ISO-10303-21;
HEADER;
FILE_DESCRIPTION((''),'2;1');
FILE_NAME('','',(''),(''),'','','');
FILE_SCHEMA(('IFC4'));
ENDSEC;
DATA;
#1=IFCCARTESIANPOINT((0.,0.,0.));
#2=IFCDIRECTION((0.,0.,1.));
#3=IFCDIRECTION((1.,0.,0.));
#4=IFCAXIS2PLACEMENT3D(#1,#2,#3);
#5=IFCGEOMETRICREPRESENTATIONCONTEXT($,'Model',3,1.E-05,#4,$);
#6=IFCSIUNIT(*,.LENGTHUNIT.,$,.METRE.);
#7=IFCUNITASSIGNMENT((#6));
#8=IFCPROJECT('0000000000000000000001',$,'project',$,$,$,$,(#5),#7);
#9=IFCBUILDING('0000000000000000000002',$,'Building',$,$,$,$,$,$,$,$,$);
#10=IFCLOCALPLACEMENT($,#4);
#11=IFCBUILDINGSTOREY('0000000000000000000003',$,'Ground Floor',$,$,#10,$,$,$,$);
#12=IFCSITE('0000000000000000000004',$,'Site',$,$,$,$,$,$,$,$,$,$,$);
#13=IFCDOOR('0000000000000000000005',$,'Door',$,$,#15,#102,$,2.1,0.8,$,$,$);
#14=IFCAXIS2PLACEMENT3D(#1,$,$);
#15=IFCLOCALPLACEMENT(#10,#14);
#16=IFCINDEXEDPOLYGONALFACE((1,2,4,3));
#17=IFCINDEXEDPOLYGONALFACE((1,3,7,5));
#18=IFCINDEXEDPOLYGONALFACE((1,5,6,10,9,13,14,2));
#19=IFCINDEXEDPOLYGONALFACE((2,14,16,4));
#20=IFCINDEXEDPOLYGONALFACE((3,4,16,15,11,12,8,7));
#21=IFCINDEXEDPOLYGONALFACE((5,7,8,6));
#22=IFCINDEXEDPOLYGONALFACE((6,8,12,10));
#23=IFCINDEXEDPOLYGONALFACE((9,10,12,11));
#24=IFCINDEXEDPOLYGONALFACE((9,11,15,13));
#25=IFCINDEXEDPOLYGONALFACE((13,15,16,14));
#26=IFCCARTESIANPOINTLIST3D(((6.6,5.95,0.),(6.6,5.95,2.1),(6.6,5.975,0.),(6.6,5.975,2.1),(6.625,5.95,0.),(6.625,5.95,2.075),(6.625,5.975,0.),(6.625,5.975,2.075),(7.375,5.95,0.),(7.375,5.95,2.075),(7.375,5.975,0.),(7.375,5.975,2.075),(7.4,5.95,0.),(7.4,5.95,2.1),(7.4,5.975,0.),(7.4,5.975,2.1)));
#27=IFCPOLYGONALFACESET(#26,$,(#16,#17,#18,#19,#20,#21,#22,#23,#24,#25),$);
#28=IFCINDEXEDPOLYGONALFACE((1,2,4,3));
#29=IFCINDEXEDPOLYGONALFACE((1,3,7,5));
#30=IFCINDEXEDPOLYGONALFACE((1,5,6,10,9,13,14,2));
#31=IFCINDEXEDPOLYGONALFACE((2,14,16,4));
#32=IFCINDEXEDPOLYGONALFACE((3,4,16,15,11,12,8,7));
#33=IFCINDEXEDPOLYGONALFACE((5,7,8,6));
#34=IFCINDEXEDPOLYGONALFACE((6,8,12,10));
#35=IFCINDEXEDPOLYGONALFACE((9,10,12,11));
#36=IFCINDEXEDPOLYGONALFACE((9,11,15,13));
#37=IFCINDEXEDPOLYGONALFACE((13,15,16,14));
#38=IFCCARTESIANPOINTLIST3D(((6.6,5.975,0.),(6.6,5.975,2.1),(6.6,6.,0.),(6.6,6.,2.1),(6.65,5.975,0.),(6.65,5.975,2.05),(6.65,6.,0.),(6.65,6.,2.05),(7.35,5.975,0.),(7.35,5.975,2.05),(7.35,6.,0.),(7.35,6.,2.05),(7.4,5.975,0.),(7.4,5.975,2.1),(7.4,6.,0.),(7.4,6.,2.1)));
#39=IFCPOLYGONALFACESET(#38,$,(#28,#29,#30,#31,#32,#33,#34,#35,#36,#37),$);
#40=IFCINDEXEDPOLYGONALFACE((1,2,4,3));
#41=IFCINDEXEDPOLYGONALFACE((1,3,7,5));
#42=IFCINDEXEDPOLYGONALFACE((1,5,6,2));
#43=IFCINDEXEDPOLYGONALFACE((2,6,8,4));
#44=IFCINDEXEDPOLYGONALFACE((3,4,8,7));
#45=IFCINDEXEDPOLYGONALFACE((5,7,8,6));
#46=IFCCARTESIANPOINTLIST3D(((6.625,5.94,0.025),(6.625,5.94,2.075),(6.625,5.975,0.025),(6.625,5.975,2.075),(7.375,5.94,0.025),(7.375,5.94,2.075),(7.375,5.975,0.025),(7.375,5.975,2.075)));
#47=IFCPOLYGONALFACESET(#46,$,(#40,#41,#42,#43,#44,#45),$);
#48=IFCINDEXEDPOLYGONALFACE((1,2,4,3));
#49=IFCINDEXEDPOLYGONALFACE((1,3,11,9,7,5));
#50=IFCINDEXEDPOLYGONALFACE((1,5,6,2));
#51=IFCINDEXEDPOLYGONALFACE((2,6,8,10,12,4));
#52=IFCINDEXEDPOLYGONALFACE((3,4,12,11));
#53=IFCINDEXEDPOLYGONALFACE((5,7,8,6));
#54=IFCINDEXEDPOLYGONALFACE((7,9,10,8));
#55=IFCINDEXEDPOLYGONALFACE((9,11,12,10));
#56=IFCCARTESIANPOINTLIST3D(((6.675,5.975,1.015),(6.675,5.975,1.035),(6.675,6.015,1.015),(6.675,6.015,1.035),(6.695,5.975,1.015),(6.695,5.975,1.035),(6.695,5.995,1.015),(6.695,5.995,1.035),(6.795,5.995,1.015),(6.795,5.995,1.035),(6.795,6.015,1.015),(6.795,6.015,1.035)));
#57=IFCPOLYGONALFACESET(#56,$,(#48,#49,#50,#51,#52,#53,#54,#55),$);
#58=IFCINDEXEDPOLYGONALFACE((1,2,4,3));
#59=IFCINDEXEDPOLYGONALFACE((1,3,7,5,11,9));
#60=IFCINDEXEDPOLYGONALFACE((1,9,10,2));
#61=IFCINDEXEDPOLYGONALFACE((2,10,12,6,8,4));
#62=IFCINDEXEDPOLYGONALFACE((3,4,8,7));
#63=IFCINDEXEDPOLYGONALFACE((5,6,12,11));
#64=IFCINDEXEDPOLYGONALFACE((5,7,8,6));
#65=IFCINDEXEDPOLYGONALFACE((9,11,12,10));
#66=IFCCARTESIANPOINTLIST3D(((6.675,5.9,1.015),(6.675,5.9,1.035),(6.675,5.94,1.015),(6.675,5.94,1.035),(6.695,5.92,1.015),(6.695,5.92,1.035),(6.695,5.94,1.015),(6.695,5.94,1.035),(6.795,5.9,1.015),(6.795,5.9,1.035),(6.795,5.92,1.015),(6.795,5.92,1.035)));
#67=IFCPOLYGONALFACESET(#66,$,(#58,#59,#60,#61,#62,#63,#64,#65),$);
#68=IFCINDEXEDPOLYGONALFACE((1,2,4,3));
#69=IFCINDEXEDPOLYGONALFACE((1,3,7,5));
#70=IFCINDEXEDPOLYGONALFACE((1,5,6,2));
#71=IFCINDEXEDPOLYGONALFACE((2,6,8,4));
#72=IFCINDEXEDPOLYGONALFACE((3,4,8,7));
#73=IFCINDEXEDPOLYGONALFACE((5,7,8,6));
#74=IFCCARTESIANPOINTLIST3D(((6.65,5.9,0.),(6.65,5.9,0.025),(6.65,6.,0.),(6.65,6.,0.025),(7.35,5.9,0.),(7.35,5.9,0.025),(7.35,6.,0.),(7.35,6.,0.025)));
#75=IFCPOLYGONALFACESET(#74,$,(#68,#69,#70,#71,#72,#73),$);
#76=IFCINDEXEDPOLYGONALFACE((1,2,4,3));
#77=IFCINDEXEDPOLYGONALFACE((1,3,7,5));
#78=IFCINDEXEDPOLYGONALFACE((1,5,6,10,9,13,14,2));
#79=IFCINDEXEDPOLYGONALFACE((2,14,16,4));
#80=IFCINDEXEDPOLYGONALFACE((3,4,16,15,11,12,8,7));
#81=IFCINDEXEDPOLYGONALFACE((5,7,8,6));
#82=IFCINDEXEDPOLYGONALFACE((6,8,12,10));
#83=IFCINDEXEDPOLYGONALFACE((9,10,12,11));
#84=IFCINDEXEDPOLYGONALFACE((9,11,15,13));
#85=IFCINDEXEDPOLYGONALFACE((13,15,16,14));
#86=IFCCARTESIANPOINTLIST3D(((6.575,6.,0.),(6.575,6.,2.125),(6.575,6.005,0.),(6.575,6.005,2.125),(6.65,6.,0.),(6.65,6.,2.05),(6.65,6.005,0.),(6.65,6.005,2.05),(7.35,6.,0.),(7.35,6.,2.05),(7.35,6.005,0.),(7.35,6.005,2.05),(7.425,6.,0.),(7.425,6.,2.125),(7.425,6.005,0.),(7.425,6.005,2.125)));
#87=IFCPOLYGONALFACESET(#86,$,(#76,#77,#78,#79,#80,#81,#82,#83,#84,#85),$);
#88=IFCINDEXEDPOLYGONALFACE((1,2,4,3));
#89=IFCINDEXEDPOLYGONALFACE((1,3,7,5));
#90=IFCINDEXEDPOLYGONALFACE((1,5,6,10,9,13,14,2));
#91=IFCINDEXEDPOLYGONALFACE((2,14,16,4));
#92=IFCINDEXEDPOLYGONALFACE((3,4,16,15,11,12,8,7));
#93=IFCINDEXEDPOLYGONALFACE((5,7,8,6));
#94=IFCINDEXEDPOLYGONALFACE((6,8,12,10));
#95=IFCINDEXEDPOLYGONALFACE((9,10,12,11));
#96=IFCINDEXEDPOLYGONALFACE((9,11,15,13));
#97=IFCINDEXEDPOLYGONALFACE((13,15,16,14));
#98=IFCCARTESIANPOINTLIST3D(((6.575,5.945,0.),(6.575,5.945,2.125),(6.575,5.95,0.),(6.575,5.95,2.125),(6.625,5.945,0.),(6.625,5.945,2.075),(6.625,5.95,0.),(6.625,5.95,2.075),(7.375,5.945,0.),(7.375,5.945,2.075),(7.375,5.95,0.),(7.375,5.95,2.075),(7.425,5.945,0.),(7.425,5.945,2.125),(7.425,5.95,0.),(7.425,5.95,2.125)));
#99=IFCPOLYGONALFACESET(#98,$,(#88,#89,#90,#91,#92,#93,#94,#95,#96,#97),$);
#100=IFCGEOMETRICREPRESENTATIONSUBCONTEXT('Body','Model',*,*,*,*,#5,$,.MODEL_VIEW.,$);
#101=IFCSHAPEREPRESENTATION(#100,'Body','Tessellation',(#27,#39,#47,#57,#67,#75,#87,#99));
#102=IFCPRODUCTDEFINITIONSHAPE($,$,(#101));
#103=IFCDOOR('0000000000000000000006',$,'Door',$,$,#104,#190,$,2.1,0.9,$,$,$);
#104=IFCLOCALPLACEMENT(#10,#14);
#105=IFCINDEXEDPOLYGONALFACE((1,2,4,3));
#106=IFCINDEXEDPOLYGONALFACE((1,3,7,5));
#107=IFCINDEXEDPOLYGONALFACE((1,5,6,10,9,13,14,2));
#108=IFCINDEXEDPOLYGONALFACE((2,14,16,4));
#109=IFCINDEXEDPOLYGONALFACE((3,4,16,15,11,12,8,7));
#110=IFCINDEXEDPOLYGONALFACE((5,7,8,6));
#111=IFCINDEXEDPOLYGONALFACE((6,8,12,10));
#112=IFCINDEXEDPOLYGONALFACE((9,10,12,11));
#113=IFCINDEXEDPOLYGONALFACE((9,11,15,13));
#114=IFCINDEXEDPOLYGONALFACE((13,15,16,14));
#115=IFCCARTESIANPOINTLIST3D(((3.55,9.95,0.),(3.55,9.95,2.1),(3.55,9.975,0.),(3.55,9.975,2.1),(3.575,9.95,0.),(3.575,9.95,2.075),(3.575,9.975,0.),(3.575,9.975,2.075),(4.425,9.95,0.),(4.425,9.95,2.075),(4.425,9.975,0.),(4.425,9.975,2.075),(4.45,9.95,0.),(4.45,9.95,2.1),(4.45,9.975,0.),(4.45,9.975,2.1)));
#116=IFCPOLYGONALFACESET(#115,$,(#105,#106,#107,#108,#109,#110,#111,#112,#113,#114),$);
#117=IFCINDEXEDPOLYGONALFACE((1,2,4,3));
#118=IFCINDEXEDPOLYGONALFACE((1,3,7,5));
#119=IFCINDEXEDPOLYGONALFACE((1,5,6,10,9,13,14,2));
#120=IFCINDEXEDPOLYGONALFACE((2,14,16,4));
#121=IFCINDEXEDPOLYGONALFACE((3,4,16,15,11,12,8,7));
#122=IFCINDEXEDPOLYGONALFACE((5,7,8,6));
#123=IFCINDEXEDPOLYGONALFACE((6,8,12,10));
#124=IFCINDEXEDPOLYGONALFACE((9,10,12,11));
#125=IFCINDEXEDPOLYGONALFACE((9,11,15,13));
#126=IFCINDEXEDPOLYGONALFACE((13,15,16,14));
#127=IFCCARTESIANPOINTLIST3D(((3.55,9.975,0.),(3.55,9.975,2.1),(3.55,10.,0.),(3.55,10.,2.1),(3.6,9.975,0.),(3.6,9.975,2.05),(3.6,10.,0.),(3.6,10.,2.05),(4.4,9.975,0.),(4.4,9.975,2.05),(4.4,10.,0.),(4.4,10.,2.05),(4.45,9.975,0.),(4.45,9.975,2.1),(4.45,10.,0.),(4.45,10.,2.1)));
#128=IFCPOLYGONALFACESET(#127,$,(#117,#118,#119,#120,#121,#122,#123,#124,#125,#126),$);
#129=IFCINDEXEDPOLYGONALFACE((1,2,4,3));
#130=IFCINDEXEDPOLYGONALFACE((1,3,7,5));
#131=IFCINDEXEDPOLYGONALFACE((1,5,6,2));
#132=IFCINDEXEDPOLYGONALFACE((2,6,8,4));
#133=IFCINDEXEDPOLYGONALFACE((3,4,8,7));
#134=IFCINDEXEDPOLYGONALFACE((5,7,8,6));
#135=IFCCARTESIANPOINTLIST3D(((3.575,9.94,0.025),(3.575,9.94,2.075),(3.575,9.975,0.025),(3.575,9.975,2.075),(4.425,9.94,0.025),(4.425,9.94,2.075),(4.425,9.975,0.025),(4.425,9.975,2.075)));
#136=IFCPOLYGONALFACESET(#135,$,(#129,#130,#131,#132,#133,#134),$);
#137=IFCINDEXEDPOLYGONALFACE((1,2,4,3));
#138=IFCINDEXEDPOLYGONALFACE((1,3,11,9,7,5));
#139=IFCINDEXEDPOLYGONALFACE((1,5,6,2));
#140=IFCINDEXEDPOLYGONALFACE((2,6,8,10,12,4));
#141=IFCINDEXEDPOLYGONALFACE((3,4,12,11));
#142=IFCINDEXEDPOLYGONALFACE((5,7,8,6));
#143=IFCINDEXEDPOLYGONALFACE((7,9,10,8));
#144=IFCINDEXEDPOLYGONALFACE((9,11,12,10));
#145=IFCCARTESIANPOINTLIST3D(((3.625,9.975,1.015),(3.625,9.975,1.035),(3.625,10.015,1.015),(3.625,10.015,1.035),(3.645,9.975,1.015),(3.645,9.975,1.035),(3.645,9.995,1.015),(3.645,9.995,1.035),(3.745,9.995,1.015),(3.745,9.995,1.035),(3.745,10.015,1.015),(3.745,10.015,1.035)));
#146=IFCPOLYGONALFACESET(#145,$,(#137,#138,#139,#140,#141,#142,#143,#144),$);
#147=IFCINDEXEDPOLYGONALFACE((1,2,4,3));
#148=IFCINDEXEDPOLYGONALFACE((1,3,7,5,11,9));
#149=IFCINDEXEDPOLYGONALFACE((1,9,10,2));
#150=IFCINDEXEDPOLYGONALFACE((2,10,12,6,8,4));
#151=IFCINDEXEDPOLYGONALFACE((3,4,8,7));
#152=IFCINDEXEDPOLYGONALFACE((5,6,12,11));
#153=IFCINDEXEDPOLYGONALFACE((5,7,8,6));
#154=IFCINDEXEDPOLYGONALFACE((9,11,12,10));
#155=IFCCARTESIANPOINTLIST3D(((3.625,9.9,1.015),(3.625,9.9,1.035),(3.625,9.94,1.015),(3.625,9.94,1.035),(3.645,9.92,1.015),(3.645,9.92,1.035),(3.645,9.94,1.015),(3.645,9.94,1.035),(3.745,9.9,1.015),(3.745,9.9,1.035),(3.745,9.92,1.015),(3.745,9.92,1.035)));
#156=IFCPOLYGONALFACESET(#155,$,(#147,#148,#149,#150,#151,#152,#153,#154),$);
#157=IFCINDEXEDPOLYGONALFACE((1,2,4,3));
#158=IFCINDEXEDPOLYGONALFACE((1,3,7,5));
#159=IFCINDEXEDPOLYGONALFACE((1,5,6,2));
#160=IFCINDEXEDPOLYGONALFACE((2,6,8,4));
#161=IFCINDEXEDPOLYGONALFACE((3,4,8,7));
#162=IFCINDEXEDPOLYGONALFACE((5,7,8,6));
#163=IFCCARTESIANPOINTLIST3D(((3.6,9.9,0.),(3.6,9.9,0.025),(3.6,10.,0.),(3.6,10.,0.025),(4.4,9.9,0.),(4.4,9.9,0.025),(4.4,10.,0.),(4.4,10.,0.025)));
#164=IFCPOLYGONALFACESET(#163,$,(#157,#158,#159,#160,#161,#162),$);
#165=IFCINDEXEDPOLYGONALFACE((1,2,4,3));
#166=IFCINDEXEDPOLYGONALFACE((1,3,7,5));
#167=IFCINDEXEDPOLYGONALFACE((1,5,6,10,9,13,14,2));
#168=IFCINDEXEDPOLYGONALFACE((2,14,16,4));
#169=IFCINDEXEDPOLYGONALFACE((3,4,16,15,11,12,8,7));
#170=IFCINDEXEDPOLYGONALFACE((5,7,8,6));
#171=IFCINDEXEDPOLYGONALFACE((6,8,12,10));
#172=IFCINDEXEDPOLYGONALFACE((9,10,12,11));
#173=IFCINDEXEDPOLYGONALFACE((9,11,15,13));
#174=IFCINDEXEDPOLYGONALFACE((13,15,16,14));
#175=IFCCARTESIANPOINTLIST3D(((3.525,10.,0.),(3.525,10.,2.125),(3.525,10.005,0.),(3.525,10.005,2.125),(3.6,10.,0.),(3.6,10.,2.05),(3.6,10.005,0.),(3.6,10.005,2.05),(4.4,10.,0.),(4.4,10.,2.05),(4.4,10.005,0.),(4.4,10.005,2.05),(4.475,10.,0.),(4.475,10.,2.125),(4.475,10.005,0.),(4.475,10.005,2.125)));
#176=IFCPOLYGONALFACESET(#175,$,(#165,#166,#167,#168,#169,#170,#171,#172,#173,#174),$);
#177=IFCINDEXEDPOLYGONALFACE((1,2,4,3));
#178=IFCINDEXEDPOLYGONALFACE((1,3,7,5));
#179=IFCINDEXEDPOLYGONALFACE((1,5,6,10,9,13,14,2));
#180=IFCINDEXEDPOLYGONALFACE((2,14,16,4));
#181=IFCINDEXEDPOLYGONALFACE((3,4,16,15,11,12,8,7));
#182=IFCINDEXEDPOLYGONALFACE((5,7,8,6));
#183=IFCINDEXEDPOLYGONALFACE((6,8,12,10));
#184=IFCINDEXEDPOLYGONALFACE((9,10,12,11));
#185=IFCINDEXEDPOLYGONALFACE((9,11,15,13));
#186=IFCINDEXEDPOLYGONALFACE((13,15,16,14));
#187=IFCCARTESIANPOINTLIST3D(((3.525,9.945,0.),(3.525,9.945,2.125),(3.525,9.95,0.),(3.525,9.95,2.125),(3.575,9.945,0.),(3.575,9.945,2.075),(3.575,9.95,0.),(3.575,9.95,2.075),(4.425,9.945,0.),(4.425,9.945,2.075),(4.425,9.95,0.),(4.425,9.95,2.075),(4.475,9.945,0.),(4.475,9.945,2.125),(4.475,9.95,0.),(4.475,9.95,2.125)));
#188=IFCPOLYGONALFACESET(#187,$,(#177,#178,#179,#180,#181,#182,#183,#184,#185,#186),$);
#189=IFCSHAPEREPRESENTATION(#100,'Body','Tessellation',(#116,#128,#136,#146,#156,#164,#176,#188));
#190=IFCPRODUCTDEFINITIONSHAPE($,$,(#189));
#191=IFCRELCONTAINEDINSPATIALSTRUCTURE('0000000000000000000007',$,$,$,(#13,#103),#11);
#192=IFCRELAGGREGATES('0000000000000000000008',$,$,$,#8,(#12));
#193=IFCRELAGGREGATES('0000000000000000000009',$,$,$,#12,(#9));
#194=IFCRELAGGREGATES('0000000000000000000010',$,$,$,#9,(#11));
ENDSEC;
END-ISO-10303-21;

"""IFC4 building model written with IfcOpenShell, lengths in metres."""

from ifc_helpers import new_model, si_unit, frame, origin_with_axes, place, context, subcontext, project, spatial, line, indexed_curve, outline, extrude, element, save


model = new_model("IFC4")

# Units and contexts
model_context = context("Model", 3, precision=1e-05, world=origin_with_axes())
body_context = subcontext(model_context, "Body", "Model", "MODEL_VIEW")
ifc_project = project(units=[si_unit("LENGTHUNIT", "METRE")], contexts=[model_context])

# Site, building, storey
site = spatial("IfcSite", under=ifc_project, Name="Site")
building = spatial("IfcBuilding", under=site, Name="Building")
storey_placement = place(None, origin_with_axes())
storey = spatial("IfcBuildingStorey", under=building, at=storey_placement, Name="Ground Floor")

# Doors
door_1_placement = place(storey_placement, frame((7.4, 6.0, 0.0), z_axis=(0.0, 0.0, 1.0), x_axis=(-1.0, 0.0, 0.0)))
element("IfcDoor", 1, at=door_1_placement, inside=storey, Name="Door", OverallHeight=2.1, OverallWidth=0.8, context=body_context, shape_type="SweptSolid", body=[
    extrude(outline(indexed_curve([(0.0, 0.0), (0.0, 2.1), (0.8, 2.1), (0.8, 0.0), (0.775, 0.0), (0.775, 2.075), (0.025, 2.075), (0.025, 0.0)], segments=[line(1, 2, 3, 4, 5, 6, 7, 8, 1)])), frame((0.0, 0.025, 0.0), z_axis=(0.0, -1.0, 0.0), x_axis=(1.0, 0.0, 0.0)), (0.0, 0.0, -1.0), 0.025),
    extrude(outline(indexed_curve([(0.0, 0.0), (0.0, 2.1), (0.8, 2.1), (0.8, 0.0), (0.75, 0.0), (0.75, 2.05), (0.05, 2.05), (0.05, 0.0)], segments=[line(1, 2, 3, 4, 5, 6, 7, 8, 1)])), frame((0.0, 0.0, 0.0), z_axis=(0.0, -1.0, 0.0), x_axis=(1.0, 0.0, 0.0)), (0.0, 0.0, -1.0), 0.025),
    extrude(outline(indexed_curve([(0.0, 0.0), (0.75, 0.0), (0.75, 0.035), (0.0, 0.035)], segments=[line(1, 2, 3, 4, 1)])), frame((0.025, 0.025, 0.025), z_axis=(0.0, 0.0, 1.0), x_axis=(1.0, 0.0, 0.0)), (0.0, 0.0, 1.0), 2.05),
    extrude(outline(indexed_curve([(0.0, 0.0), (0.0, -0.04), (-0.12, -0.04), (-0.12, -0.02), (-0.02, -0.02), (-0.02, 0.0)], segments=[line(1, 2, 3, 4, 5, 6, 1)])), frame((0.725, 0.025, 1.015), z_axis=(0.0, 0.0, 1.0), x_axis=(1.0, 0.0, 0.0)), (0.0, 0.0, 1.0), 0.02),
    extrude(outline(indexed_curve([(0.0, 0.0), (0.0, 0.04), (-0.12, 0.04), (-0.12, 0.02), (-0.02, 0.02), (-0.02, 0.0)], segments=[line(1, 2, 3, 4, 5, 6, 1)])), frame((0.725, 0.06, 1.015), z_axis=(0.0, 0.0, 1.0), x_axis=(1.0, 0.0, 0.0)), (0.0, 0.0, 1.0), 0.02),
    extrude(outline(indexed_curve([(0.0, 0.0), (0.7, 0.0), (0.7, 0.1), (0.0, 0.1)], segments=[line(1, 2, 3, 4, 1)])), frame((0.05, 0.0, 0.0), z_axis=(0.0, 0.0, 1.0), x_axis=(1.0, 0.0, 0.0)), (0.0, 0.0, 1.0), 0.025),
    extrude(outline(indexed_curve([(0.0, 0.0), (0.0, 2.125), (0.85, 2.125), (0.85, 0.0), (0.775, 0.0), (0.775, 2.05), (0.075, 2.05), (0.075, 0.0)], segments=[line(1, 2, 3, 4, 5, 6, 7, 8, 1)])), frame((-0.025, -0.005, 0.0), z_axis=(0.0, -1.0, 0.0), x_axis=(1.0, 0.0, 0.0)), (0.0, 0.0, -1.0), 0.005),
    extrude(outline(indexed_curve([(0.0, 0.0), (0.0, 2.125), (0.85, 2.125), (0.85, 0.0), (0.8, 0.0), (0.8, 2.075), (0.05, 2.075), (0.05, 0.0)], segments=[line(1, 2, 3, 4, 5, 6, 7, 8, 1)])), frame((-0.025, 0.05, 0.0), z_axis=(0.0, -1.0, 0.0), x_axis=(1.0, 0.0, 0.0)), (0.0, 0.0, -1.0), 0.005),
])
door_2_placement = place(storey_placement, frame((4.45, 10.0, 0.0), z_axis=(0.0, 0.0, 1.0), x_axis=(-1.0, 0.0, 0.0)))
element("IfcDoor", 2, at=door_2_placement, inside=storey, Name="Door", OverallHeight=2.1, OverallWidth=0.9, context=body_context, shape_type="SweptSolid", body=[
    extrude(outline(indexed_curve([(0.0, 0.0), (0.0, 2.1), (0.9, 2.1), (0.9, 0.0), (0.875, 0.0), (0.875, 2.075), (0.025, 2.075), (0.025, 0.0)], segments=[line(1, 2, 3, 4, 5, 6, 7, 8, 1)])), frame((0.0, 0.025, 0.0), z_axis=(0.0, -1.0, 0.0), x_axis=(1.0, 0.0, 0.0)), (0.0, 0.0, -1.0), 0.025),
    extrude(outline(indexed_curve([(0.0, 0.0), (0.0, 2.1), (0.9, 2.1), (0.9, 0.0), (0.85, 0.0), (0.85, 2.05), (0.05, 2.05), (0.05, 0.0)], segments=[line(1, 2, 3, 4, 5, 6, 7, 8, 1)])), frame((0.0, 0.0, 0.0), z_axis=(0.0, -1.0, 0.0), x_axis=(1.0, 0.0, 0.0)), (0.0, 0.0, -1.0), 0.025),
    extrude(outline(indexed_curve([(0.0, 0.0), (0.85, 0.0), (0.85, 0.035), (0.0, 0.035)], segments=[line(1, 2, 3, 4, 1)])), frame((0.025, 0.025, 0.025), z_axis=(0.0, 0.0, 1.0), x_axis=(1.0, 0.0, 0.0)), (0.0, 0.0, 1.0), 2.05),
    extrude(outline(indexed_curve([(0.0, 0.0), (0.0, -0.04), (-0.12, -0.04), (-0.12, -0.02), (-0.02, -0.02), (-0.02, 0.0)], segments=[line(1, 2, 3, 4, 5, 6, 1)])), frame((0.825, 0.025, 1.015), z_axis=(0.0, 0.0, 1.0), x_axis=(1.0, 0.0, 0.0)), (0.0, 0.0, 1.0), 0.02),
    extrude(outline(indexed_curve([(0.0, 0.0), (0.0, 0.04), (-0.12, 0.04), (-0.12, 0.02), (-0.02, 0.02), (-0.02, 0.0)], segments=[line(1, 2, 3, 4, 5, 6, 1)])), frame((0.825, 0.06, 1.015), z_axis=(0.0, 0.0, 1.0), x_axis=(1.0, 0.0, 0.0)), (0.0, 0.0, 1.0), 0.02),
    extrude(outline(indexed_curve([(0.0, 0.0), (0.8, 0.0), (0.8, 0.1), (0.0, 0.1)], segments=[line(1, 2, 3, 4, 1)])), frame((0.05, 0.0, 0.0), z_axis=(0.0, 0.0, 1.0), x_axis=(1.0, 0.0, 0.0)), (0.0, 0.0, 1.0), 0.025),
    extrude(outline(indexed_curve([(0.0, 0.0), (0.0, 2.125), (0.95, 2.125), (0.95, 0.0), (0.875, 0.0), (0.875, 2.05), (0.075, 2.05), (0.075, 0.0)], segments=[line(1, 2, 3, 4, 5, 6, 7, 8, 1)])), frame((-0.025, -0.005, 0.0), z_axis=(0.0, -1.0, 0.0), x_axis=(1.0, 0.0, 0.0)), (0.0, 0.0, -1.0), 0.005),
    extrude(outline(indexed_curve([(0.0, 0.0), (0.0, 2.125), (0.95, 2.125), (0.95, 0.0), (0.9, 0.0), (0.9, 2.075), (0.05, 2.075), (0.05, 0.0)], segments=[line(1, 2, 3, 4, 5, 6, 7, 8, 1)])), frame((-0.025, 0.05, 0.0), z_axis=(0.0, -1.0, 0.0), x_axis=(1.0, 0.0, 0.0)), (0.0, 0.0, -1.0), 0.005),
])

save(model, "model.ifc")
